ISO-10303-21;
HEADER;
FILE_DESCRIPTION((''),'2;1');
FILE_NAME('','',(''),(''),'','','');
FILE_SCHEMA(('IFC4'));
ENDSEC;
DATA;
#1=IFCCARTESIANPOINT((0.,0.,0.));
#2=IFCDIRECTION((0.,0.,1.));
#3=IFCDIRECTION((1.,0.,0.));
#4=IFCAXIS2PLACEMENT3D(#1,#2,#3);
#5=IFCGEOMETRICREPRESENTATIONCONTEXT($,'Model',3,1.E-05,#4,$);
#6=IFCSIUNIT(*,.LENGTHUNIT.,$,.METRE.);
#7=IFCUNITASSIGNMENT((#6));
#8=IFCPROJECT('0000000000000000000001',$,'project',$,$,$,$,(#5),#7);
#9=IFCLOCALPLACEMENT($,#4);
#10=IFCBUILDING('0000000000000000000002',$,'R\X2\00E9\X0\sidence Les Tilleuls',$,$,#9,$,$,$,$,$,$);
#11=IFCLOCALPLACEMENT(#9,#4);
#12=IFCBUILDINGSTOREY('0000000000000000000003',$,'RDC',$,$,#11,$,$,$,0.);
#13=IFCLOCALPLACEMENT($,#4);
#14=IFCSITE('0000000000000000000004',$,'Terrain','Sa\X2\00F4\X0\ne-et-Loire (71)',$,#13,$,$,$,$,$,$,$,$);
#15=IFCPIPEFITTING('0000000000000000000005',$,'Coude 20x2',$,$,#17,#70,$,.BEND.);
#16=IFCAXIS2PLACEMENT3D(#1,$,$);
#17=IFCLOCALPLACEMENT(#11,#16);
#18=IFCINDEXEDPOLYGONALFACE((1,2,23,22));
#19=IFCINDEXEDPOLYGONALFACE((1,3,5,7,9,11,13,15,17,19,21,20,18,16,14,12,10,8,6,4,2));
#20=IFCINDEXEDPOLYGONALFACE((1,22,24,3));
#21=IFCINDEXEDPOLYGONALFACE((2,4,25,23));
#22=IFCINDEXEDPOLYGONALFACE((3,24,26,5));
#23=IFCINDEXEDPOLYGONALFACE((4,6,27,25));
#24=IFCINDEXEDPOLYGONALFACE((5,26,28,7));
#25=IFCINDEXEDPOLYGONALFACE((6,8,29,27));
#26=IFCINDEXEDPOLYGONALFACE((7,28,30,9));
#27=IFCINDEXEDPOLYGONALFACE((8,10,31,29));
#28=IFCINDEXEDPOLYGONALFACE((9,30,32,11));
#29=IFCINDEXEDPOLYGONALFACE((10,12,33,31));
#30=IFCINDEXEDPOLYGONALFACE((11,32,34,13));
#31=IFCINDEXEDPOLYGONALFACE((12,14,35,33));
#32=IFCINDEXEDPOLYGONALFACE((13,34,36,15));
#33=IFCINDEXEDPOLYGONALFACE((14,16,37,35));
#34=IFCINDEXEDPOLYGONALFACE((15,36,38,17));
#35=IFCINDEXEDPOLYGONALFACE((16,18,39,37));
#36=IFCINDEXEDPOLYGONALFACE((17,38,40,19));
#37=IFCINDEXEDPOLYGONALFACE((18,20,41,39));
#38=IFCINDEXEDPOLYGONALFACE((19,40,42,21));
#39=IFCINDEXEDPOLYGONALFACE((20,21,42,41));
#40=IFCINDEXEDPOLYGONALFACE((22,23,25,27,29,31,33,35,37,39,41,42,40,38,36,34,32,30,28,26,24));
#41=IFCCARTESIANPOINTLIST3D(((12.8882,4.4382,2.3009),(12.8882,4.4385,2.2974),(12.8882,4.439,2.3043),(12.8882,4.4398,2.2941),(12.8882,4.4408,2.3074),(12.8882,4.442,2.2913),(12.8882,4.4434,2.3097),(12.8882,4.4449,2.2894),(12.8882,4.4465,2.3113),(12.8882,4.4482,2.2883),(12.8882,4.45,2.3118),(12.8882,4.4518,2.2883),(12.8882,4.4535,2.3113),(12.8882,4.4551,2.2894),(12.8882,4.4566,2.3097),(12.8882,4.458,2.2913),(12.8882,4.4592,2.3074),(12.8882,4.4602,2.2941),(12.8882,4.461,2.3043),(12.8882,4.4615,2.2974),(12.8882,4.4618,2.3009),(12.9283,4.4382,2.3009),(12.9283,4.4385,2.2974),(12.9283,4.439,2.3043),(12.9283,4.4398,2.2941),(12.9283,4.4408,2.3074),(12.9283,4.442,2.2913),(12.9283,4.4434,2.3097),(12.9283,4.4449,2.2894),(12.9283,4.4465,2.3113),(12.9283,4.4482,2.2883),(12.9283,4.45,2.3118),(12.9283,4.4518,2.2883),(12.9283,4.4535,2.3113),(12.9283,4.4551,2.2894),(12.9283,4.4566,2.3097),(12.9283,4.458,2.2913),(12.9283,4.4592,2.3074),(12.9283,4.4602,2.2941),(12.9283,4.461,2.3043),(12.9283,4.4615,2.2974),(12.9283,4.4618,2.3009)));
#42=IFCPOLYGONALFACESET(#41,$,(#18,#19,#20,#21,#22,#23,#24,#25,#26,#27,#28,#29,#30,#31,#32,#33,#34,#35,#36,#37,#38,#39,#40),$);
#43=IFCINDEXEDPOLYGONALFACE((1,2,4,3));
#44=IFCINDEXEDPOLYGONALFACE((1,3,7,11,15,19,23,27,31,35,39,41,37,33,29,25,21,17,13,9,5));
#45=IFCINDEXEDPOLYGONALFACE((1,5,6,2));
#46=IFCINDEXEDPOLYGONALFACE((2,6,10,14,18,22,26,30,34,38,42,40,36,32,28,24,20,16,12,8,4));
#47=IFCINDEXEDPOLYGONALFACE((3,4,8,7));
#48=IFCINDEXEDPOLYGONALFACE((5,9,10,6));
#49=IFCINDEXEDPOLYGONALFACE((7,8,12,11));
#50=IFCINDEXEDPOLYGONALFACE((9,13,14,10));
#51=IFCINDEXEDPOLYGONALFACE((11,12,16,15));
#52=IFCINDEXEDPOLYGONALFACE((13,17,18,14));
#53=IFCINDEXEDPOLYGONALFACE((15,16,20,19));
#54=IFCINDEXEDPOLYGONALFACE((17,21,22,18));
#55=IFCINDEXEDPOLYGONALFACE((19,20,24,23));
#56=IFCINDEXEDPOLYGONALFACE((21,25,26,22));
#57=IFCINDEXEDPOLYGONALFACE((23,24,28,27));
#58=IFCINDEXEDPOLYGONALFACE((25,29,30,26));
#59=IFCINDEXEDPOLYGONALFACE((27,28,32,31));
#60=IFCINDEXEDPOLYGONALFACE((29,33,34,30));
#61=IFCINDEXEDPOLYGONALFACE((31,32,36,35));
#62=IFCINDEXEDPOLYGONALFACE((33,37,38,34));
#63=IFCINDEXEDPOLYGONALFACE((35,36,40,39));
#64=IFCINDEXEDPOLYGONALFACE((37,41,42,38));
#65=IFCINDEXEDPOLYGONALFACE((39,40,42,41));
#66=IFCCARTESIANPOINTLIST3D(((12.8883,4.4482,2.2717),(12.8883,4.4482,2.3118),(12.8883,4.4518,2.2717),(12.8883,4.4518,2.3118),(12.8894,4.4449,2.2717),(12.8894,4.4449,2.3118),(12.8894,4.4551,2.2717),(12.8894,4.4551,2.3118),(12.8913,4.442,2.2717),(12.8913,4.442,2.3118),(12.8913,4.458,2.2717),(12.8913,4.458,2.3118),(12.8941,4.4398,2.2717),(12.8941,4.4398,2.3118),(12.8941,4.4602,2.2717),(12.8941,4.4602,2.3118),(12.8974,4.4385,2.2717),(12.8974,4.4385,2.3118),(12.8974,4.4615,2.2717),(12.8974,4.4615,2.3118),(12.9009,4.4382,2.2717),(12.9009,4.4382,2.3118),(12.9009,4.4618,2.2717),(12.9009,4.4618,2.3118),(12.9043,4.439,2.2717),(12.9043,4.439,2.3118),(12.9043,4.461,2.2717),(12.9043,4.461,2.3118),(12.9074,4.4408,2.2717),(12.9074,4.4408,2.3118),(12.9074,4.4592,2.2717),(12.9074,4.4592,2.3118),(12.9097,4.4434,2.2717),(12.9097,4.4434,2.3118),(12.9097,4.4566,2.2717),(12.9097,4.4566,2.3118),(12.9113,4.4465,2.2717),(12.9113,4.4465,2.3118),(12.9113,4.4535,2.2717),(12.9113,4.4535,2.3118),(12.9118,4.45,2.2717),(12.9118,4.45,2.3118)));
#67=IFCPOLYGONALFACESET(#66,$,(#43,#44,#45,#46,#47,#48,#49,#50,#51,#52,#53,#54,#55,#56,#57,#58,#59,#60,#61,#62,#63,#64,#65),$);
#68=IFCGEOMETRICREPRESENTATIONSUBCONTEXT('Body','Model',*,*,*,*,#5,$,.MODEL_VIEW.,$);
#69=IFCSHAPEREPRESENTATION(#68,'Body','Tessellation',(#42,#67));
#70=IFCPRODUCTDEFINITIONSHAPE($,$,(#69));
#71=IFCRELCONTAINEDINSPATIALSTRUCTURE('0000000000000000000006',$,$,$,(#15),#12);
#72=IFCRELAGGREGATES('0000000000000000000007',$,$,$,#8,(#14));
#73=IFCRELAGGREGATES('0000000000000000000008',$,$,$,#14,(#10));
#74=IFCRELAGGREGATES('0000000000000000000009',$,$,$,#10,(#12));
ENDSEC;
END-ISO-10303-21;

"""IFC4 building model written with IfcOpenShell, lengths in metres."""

from ifc_helpers import new_model, si_unit, frame, origin_with_axes, place, context, subcontext, project, spatial, circle, extrude, element, save


model = new_model("IFC4")

# Units and contexts
model_context = context("Model", 3, precision=1e-05, world=origin_with_axes())
body_context = subcontext(model_context, "Body", "Model", "MODEL_VIEW")
ifc_project = project(units=[si_unit("LENGTHUNIT", "METRE")], contexts=[model_context])

# Site, building, storey
site_placement = place(None, origin_with_axes())
site = spatial("IfcSite", under=ifc_project, at=site_placement, Name="Terrain", Description="Saône-et-Loire (71)")
building_placement = place(None, origin_with_axes())
building = spatial("IfcBuilding", under=site, at=building_placement, Name="Résidence Les Tilleuls")
storey_placement = place(building_placement, origin_with_axes())
storey = spatial("IfcBuildingStorey", under=building, at=storey_placement, Name="RDC", Elevation=0.0)

# Pipe fitting
pipe_fitting_1_placement = place(storey_placement, frame((12.9, 4.45, 2.3), z_axis=(0.0, 0.0, 1.0), x_axis=(1.0, 0.0, 0.0)))
element("IfcPipeFitting", 1, at=pipe_fitting_1_placement, inside=storey, Name="Coude 20x2", PredefinedType="BEND", context=body_context, shape_type="SweptSolid", body=[
    extrude(circle(Radius=0.0118), frame((-0.0118, 0.0, 0.0), z_axis=(1.0, 0.0, 0.0), x_axis=(0.0, 0.0, 1.0)), (0.0, 0.0, 1.0), 0.0401),
    extrude(circle(Radius=0.0118), frame((0.0, 0.0, 0.0118), z_axis=(0.0, 0.0, -1.0), x_axis=(1.0, 0.0, 0.0)), (0.0, 0.0, 1.0), 0.0401),
])

save(model, "model.ifc")
